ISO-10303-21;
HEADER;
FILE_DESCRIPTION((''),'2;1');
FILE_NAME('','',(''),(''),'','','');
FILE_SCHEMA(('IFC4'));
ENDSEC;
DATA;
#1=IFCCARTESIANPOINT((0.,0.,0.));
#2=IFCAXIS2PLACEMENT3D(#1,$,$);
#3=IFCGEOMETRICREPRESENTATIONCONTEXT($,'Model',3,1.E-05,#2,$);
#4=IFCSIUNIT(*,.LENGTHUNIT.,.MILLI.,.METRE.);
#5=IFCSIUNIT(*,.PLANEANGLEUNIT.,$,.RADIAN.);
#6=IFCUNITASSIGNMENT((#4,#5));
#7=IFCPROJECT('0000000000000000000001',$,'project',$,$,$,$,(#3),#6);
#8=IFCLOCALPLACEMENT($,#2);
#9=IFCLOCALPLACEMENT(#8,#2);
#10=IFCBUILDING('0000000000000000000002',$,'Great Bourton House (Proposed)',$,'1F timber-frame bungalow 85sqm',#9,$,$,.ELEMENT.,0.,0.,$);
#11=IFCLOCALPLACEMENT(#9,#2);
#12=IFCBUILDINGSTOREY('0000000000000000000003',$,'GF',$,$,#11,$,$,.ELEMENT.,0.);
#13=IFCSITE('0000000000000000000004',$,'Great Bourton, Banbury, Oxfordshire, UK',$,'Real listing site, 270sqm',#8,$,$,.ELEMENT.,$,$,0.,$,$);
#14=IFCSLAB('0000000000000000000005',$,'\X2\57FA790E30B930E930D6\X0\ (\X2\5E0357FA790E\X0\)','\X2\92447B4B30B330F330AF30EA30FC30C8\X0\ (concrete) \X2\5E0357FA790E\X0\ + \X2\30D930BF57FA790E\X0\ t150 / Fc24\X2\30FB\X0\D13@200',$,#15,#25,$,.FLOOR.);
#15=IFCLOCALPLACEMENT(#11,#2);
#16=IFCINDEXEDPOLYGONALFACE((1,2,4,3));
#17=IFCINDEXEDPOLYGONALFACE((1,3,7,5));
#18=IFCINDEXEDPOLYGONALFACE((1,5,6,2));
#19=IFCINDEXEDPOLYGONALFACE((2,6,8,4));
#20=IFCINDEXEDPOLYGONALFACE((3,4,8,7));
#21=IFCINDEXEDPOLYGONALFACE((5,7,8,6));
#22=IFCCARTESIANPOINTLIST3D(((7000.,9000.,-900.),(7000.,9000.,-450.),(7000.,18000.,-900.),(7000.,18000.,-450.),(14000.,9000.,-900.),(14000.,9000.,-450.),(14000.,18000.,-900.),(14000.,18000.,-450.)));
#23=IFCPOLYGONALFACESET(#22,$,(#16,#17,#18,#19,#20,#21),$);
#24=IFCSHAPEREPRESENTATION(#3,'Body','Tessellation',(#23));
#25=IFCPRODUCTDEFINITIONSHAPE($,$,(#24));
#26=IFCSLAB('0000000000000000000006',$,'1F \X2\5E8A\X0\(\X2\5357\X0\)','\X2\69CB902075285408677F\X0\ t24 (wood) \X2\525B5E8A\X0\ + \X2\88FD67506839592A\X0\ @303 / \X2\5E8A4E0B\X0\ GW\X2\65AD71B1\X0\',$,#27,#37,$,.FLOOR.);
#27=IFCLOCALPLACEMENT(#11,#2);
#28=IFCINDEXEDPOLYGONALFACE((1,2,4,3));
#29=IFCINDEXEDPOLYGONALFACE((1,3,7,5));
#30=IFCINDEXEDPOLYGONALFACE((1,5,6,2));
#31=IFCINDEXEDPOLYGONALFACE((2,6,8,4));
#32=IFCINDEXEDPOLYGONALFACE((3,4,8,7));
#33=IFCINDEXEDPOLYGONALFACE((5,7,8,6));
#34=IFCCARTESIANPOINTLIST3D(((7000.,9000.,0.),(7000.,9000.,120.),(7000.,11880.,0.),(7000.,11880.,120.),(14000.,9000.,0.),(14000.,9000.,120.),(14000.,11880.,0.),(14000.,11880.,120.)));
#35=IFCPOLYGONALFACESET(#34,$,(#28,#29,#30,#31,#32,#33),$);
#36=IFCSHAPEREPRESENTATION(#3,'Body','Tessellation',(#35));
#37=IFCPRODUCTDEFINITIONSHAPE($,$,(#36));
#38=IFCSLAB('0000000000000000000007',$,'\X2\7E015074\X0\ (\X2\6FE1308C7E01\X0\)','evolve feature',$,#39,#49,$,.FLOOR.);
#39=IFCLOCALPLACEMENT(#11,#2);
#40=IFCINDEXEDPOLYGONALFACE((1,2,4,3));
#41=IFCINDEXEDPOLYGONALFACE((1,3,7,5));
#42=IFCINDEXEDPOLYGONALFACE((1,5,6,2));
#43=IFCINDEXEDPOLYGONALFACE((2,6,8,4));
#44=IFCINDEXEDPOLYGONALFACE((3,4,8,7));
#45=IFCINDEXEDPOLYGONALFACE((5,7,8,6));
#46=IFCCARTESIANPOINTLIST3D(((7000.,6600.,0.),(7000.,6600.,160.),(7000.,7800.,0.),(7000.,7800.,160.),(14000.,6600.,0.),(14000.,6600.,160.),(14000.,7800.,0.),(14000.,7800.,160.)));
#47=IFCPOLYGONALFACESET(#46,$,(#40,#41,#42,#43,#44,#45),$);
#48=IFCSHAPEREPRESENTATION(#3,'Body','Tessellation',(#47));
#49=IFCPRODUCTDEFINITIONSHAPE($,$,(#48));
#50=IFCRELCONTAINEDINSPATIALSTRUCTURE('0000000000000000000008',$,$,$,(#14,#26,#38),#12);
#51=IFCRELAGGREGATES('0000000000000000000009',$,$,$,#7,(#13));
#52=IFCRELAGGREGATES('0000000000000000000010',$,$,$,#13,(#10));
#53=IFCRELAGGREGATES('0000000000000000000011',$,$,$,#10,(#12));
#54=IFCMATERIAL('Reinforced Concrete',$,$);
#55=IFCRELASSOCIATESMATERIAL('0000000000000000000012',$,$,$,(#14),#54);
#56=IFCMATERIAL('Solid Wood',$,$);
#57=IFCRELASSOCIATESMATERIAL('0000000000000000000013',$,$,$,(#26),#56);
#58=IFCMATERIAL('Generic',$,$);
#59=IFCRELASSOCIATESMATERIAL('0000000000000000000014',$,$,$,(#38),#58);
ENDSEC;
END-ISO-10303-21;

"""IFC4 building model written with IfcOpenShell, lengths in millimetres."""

from ifc_helpers import new_model, si_unit, frame, frame_2d, origin, place, context, project, spatial, rectangle, extrude, material, element, save


model = new_model("IFC4")

# Units and contexts
model_context = context("Model", 3, precision=1e-05, world=origin())
ifc_project = project(units=[si_unit("LENGTHUNIT", "METRE", prefix="MILLI"), si_unit("PLANEANGLEUNIT", "RADIAN")], contexts=[model_context])

# Site, building, storey
site_placement = place(None, origin())
site = spatial("IfcSite", under=ifc_project, at=site_placement, Name="Great Bourton, Banbury, Oxfordshire, UK", ObjectType="Real listing site, 270sqm", CompositionType="ELEMENT", RefElevation=0.0)
building_placement = place(site_placement, origin())
building = spatial("IfcBuilding", under=site, at=building_placement, Name="Great Bourton House (Proposed)", ObjectType="1F timber-frame bungalow 85sqm", CompositionType="ELEMENT", ElevationOfRefHeight=0.0, ElevationOfTerrain=0.0)
storey_placement = place(building_placement, origin())
storey = spatial("IfcBuildingStorey", under=building, at=storey_placement, Name="GF", CompositionType="ELEMENT", Elevation=0.0)

# Slabs
ifc_material_1 = material(Name="Reinforced Concrete")
slab_1_placement = place(storey_placement, frame((3500.0, 4500.0, -450.0)))
element("IfcSlab", 1, at=slab_1_placement, inside=storey, material=ifc_material_1, Name="基礎スラブ (布基礎)", Description="鉄筋コンクリート (concrete) 布基礎 + ベタ基礎 t150 / Fc24・D13@200", PredefinedType="FLOOR", context=model_context, shape_type="SweptSolid", body=[
    extrude(rectangle(XDim=7000.0, YDim=9000.0, at=frame_2d((3500.0, 4500.0))), frame((3500.0, 4500.0, -450.0)), (0.0, 0.0, 1.0), 450.0),
])
ifc_material_2 = material(Name="Solid Wood")
slab_2_placement = place(storey_placement, frame((3500.0, 4500.0, 0.0)))
element("IfcSlab", 2, at=slab_2_placement, inside=storey, material=ifc_material_2, Name="1F 床(南)", Description="構造用合板 t24 (wood) 剛床 + 製材根太 @303 / 床下 GW断熱", PredefinedType="FLOOR", context=model_context, shape_type="SweptSolid", body=[
    extrude(rectangle(XDim=7000.0, YDim=2880.0, at=frame_2d((3500.0, 1440.0))), frame((3500.0, 4500.0, 0.0)), (0.0, 0.0, 1.0), 120.0),
])
ifc_material_3 = material(Name="Generic")
slab_3_placement = place(storey_placement, frame((3500.0, 3300.0, 0.0)))
element("IfcSlab", 3, at=slab_3_placement, inside=storey, material=ifc_material_3, Name="縁側 (濡れ縁)", Description="evolve feature", PredefinedType="FLOOR", context=model_context, shape_type="SweptSolid", body=[
    extrude(rectangle(XDim=7000.0, YDim=1200.0, at=frame_2d((3500.0, 600.0))), frame((3500.0, 3300.0, 0.0)), (0.0, 0.0, 1.0), 160.0),
])

save(model, "model.ifc")
